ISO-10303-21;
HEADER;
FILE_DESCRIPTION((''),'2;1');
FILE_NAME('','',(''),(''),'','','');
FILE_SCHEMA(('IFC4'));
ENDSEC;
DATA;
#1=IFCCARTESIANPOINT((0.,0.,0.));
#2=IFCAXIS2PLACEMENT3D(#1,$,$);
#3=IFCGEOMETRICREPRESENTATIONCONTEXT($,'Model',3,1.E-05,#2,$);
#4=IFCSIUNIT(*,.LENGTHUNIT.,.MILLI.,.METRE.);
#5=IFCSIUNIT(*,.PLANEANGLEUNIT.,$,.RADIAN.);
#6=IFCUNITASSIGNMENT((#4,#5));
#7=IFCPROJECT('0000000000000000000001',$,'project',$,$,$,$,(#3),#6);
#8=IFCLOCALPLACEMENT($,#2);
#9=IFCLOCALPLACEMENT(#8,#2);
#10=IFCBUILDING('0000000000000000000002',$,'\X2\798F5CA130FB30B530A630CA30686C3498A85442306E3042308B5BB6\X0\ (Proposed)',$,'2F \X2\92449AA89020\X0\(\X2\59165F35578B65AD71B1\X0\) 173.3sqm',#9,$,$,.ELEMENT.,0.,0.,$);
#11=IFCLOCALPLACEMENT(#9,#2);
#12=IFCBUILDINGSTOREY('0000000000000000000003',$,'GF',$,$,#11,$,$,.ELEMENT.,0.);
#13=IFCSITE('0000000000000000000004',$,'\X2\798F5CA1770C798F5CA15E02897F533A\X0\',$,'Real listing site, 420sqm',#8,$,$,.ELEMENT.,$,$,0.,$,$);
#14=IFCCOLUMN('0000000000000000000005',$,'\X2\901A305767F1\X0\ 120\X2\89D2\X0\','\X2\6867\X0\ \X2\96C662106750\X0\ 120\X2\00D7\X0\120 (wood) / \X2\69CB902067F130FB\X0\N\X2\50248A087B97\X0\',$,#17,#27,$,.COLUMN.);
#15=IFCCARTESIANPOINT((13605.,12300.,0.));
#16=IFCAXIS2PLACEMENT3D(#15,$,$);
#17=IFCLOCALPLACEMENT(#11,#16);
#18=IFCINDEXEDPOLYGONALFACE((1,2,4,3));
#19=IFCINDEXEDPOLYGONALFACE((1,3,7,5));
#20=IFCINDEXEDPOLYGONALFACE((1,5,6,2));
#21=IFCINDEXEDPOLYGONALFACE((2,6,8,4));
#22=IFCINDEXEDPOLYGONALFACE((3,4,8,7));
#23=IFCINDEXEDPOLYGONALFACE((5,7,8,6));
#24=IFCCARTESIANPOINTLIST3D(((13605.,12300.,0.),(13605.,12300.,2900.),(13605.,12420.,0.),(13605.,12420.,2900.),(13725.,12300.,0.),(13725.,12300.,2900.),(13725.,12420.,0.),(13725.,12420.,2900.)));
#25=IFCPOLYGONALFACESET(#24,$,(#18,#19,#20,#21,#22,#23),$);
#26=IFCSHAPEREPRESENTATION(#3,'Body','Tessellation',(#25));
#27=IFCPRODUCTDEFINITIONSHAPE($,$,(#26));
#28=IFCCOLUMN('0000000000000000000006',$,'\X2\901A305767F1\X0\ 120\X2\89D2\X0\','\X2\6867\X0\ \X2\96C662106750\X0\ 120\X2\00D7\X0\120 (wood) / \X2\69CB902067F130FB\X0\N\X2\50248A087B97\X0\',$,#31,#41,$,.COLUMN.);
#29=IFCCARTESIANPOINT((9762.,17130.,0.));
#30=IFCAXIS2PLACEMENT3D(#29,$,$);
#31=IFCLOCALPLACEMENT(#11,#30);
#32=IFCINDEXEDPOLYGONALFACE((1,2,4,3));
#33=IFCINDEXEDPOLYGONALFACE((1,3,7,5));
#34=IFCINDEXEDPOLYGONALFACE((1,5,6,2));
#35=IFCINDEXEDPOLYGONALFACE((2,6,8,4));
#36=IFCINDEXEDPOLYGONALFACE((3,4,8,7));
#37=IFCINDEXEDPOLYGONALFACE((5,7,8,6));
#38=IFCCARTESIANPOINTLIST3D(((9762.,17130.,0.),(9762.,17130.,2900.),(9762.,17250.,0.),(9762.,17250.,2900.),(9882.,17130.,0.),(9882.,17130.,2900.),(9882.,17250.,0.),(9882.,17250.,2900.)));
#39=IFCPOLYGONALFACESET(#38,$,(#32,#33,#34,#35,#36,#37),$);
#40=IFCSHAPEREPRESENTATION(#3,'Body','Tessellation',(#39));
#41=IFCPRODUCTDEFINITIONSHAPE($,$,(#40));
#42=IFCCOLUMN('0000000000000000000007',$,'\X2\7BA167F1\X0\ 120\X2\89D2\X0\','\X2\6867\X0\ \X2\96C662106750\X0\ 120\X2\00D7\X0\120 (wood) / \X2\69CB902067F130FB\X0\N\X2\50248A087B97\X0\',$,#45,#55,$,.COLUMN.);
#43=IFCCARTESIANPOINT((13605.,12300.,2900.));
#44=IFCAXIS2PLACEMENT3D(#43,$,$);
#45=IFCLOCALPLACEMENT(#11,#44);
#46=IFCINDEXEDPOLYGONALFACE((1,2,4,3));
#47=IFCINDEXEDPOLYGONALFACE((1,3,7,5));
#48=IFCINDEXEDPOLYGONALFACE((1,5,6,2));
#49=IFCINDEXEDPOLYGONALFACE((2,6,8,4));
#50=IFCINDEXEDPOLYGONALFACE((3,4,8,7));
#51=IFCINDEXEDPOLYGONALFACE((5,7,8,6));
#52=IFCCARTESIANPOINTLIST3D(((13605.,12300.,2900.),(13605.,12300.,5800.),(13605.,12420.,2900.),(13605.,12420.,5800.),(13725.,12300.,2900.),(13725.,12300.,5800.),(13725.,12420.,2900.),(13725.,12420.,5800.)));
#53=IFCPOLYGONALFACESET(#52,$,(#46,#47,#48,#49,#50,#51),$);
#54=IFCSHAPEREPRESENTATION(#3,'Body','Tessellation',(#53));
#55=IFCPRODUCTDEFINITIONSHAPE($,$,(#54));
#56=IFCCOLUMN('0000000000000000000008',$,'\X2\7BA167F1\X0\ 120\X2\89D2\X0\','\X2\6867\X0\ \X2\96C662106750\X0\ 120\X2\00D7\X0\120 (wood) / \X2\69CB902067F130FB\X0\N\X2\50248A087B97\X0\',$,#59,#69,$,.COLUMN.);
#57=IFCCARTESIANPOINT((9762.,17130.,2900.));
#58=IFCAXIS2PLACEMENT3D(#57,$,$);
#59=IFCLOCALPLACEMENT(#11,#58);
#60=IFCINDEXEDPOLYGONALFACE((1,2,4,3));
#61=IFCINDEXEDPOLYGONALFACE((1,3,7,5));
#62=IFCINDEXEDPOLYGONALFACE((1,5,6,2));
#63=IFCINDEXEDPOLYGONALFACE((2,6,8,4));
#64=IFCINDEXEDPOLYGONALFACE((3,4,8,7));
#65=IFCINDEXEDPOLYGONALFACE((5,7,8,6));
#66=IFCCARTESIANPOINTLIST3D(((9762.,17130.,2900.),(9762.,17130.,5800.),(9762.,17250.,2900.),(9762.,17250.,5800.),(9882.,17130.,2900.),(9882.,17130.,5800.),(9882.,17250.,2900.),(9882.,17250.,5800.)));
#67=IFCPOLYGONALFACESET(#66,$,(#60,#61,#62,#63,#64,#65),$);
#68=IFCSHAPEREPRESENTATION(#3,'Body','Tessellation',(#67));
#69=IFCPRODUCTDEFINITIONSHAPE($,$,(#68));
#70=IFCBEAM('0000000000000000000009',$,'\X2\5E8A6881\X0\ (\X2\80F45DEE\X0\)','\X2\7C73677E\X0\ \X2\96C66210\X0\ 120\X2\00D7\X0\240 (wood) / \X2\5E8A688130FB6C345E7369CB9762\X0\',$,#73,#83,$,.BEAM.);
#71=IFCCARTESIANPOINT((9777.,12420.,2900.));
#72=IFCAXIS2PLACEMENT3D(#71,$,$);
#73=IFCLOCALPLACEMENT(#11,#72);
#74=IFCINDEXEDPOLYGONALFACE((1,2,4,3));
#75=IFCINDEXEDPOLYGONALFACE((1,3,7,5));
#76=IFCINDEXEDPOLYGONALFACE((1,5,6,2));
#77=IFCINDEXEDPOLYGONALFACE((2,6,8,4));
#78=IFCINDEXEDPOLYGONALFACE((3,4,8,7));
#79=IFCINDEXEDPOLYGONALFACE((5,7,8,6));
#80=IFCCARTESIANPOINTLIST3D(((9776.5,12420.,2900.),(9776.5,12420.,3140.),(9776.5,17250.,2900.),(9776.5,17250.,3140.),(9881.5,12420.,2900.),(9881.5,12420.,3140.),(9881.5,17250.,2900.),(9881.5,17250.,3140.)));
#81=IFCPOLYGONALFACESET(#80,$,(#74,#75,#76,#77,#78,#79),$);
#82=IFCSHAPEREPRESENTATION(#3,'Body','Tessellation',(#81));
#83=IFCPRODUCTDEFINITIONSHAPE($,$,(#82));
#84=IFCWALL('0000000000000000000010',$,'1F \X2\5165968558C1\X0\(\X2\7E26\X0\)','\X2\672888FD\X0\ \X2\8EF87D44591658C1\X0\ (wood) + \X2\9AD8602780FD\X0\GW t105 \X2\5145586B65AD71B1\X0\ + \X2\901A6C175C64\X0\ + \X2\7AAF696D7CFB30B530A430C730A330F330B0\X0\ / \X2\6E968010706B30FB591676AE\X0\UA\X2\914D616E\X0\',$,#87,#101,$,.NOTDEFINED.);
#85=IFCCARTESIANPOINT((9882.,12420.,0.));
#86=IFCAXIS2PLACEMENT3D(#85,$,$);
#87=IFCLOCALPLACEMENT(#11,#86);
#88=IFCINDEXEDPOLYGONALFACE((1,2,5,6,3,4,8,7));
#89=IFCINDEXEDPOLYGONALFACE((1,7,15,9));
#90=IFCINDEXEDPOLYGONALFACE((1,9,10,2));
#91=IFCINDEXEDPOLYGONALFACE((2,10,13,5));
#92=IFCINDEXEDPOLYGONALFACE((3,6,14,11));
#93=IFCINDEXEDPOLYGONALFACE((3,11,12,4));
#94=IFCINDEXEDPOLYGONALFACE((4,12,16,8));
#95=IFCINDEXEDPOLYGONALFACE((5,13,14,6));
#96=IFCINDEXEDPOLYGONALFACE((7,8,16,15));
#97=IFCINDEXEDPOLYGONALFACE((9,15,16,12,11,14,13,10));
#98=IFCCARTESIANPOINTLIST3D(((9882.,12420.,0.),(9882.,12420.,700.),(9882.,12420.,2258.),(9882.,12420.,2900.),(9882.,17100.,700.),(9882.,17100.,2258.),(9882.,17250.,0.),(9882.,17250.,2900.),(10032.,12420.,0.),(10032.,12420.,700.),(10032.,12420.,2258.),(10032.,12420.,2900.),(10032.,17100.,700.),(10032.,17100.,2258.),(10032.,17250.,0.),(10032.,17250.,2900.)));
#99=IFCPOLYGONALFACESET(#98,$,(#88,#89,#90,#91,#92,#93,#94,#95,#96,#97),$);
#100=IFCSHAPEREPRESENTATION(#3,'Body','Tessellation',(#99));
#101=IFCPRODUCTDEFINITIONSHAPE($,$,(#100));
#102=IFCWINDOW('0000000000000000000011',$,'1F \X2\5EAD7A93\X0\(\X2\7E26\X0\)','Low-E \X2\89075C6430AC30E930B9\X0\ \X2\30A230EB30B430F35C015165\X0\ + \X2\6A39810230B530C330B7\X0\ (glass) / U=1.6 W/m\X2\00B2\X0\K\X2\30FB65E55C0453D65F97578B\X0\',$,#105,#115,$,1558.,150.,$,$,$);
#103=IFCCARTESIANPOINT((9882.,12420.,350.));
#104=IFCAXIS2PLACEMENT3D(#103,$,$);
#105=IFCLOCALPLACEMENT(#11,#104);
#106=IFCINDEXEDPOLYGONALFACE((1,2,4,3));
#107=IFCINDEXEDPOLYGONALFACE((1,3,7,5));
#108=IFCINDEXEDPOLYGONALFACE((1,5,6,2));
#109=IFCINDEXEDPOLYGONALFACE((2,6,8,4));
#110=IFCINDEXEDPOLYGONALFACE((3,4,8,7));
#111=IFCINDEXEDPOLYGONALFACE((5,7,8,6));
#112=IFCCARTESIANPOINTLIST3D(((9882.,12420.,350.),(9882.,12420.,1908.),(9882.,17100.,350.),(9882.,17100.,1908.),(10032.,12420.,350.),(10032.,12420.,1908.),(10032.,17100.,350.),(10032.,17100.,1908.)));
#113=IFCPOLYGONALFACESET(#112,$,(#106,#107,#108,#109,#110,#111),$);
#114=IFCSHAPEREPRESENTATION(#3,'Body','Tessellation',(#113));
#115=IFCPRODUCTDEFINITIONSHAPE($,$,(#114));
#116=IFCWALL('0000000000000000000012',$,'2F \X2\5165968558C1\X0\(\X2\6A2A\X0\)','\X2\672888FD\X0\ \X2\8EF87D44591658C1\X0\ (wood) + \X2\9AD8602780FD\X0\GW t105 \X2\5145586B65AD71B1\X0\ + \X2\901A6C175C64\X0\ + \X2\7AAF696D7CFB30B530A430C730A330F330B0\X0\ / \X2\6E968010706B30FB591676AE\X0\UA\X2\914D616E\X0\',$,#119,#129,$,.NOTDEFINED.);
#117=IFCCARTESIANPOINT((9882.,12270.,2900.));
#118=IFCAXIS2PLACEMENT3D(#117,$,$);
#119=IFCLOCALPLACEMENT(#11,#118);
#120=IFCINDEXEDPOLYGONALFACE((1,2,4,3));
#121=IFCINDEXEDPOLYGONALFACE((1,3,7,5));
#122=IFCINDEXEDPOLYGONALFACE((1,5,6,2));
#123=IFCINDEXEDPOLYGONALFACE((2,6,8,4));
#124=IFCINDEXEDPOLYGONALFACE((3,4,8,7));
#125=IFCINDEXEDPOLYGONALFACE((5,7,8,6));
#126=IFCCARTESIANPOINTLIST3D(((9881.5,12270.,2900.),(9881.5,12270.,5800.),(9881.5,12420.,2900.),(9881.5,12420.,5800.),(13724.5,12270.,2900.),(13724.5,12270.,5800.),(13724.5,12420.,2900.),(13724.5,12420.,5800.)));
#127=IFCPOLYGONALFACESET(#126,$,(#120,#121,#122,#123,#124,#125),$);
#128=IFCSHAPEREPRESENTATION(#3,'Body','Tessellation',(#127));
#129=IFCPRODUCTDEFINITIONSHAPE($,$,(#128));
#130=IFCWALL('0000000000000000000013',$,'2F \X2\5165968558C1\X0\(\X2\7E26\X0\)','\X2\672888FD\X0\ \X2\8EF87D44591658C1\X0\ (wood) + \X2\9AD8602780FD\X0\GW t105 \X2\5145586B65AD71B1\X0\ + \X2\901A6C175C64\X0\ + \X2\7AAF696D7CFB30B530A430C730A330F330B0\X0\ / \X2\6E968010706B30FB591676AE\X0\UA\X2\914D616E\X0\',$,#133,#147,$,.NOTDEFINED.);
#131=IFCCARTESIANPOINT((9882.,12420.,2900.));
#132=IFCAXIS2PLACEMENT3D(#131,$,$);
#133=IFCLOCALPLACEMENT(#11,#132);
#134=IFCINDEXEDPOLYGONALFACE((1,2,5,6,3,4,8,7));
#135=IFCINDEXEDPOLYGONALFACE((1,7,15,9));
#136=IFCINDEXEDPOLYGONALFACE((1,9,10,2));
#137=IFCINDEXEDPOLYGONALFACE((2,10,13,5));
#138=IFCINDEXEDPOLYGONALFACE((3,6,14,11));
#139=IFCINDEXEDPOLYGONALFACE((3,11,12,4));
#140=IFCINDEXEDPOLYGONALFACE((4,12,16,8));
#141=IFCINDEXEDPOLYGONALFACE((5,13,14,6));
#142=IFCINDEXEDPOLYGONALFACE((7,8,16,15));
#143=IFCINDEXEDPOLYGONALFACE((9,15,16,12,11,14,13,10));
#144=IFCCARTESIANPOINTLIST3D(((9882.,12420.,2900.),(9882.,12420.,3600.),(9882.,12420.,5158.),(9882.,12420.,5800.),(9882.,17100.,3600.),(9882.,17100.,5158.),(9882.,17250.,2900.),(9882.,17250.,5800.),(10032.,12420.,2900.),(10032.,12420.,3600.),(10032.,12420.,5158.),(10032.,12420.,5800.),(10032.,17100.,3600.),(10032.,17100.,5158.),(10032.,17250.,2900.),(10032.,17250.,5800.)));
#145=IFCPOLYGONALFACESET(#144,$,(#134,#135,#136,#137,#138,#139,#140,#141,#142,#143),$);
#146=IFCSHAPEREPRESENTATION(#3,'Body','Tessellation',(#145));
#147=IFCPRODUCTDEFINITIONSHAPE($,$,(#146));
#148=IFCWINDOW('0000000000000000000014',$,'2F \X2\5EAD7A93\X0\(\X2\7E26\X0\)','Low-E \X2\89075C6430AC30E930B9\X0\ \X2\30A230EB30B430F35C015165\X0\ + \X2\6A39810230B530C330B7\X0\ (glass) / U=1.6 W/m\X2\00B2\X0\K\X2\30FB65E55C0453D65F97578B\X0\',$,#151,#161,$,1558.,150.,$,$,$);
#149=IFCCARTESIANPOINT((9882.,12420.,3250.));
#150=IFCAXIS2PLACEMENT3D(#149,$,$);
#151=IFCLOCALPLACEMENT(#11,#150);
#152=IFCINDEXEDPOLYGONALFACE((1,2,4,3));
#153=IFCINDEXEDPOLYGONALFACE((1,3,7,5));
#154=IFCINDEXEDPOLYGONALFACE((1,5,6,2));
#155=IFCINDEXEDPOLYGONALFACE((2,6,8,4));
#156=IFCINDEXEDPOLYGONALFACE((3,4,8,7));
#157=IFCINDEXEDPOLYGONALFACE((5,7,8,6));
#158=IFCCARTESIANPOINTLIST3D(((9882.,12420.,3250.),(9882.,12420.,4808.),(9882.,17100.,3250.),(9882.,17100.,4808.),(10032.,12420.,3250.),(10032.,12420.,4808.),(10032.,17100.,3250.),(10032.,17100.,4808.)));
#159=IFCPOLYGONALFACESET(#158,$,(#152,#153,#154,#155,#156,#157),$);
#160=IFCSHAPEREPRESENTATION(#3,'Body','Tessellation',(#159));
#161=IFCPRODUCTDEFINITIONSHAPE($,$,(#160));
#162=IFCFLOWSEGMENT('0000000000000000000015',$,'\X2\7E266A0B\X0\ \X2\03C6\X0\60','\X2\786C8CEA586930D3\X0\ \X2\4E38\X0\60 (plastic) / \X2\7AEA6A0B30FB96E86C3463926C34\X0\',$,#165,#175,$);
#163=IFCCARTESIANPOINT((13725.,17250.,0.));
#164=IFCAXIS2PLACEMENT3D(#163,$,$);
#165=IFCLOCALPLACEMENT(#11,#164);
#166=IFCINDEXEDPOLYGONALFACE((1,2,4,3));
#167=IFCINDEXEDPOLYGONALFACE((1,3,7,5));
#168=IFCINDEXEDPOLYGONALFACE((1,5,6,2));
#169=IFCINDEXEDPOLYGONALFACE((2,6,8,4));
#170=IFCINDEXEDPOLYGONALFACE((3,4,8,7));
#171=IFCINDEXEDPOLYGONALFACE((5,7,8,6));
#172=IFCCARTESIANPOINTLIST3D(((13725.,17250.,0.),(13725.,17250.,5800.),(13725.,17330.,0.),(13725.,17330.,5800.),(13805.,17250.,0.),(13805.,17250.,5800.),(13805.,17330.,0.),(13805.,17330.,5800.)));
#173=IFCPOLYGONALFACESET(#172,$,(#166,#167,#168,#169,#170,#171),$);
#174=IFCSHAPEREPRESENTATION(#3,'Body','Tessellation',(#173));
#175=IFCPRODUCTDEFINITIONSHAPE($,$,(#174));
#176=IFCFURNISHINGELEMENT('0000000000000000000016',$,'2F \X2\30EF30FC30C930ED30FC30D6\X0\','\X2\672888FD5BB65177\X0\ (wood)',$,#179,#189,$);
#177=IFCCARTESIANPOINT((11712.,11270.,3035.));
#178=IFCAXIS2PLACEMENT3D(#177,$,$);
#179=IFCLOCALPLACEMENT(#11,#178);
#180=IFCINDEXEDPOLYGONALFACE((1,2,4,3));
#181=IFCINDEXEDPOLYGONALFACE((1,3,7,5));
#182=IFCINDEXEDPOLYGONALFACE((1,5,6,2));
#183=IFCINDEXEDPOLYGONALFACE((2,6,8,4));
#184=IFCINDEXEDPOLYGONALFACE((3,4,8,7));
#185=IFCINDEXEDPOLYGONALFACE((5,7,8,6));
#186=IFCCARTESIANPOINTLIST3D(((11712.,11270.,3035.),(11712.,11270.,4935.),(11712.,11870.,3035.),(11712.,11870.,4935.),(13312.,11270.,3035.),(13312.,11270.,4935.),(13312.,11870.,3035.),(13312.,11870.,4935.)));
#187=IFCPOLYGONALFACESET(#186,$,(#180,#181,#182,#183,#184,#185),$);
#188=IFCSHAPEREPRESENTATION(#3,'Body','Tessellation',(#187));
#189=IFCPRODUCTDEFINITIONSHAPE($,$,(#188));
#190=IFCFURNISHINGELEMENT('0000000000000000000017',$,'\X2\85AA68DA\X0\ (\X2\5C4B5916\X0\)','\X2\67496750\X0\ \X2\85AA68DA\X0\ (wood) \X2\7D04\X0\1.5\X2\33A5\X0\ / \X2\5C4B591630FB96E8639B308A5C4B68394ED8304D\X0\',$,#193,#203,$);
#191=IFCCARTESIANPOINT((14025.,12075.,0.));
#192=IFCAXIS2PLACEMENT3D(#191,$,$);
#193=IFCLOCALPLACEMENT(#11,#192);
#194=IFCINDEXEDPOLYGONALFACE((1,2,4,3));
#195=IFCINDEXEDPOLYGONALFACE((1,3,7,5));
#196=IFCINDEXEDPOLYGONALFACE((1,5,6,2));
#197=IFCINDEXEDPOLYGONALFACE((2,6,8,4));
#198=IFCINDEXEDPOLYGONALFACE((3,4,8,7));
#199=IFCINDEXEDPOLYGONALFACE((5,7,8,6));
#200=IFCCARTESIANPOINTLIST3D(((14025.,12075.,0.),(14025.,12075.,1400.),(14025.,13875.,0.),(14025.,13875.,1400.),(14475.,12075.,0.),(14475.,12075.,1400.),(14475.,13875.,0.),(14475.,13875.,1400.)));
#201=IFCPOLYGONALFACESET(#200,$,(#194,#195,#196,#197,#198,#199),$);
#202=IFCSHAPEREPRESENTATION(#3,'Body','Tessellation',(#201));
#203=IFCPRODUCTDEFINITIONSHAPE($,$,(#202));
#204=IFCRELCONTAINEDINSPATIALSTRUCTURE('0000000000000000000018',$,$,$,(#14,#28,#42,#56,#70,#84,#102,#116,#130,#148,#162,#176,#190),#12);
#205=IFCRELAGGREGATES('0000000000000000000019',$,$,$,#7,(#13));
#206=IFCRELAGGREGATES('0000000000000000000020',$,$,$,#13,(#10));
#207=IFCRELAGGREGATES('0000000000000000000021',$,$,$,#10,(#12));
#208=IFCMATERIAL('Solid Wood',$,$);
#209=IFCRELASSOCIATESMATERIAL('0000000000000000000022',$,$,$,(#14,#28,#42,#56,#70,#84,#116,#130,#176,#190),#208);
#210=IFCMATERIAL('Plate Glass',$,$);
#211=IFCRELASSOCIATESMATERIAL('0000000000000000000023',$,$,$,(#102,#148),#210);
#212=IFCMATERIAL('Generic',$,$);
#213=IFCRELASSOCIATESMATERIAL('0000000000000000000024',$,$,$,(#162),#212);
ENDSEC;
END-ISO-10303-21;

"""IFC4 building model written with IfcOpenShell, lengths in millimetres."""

from ifc_helpers import new_model, si_unit, frame, frame_2d, origin, place, context, project, spatial, rectangle, extrude, material, element, fill, save


model = new_model("IFC4")

# Units and contexts
model_context = context("Model", 3, precision=1e-05, world=origin())
ifc_project = project(units=[si_unit("LENGTHUNIT", "METRE", prefix="MILLI"), si_unit("PLANEANGLEUNIT", "RADIAN")], contexts=[model_context])

# Site, building, storey
site_placement = place(None, origin())
site = spatial("IfcSite", under=ifc_project, at=site_placement, Name="福岡県福岡市西区", ObjectType="Real listing site, 420sqm", CompositionType="ELEMENT", RefElevation=0.0)
building_placement = place(site_placement, origin())
building = spatial("IfcBuilding", under=site, at=building_placement, Name="福岡・サウナと水風呂のある家 (Proposed)", ObjectType="2F 鉄骨造(外張型断熱) 173.3sqm", CompositionType="ELEMENT", ElevationOfRefHeight=0.0, ElevationOfTerrain=0.0)
storey_placement = place(building_placement, origin())
storey = spatial("IfcBuildingStorey", under=building, at=storey_placement, Name="GF", CompositionType="ELEMENT", Elevation=0.0)

# Columns
ifc_material_1 = material(Name="Solid Wood")
column_1_placement = place(storey_placement, frame((13605.0, 12300.0, 0.0)))
element("IfcColumn", 1, at=column_1_placement, inside=storey, material=ifc_material_1, Name="通し柱 120角", Description="桧 集成材 120×120 (wood) / 構造柱・N値計算", PredefinedType="COLUMN", context=model_context, shape_type="SweptSolid", body=[
    extrude(rectangle(XDim=120.0, YDim=120.0, at=frame_2d((60.0, 60.0))), frame((13605.0, 12300.0, 0.0)), (0.0, 0.0, 1.0), 2900.0),
])
column_2_placement = place(storey_placement, frame((9762.0, 17130.0, 0.0)))
element("IfcColumn", 2, at=column_2_placement, inside=storey, material=ifc_material_1, Name="通し柱 120角", Description="桧 集成材 120×120 (wood) / 構造柱・N値計算", PredefinedType="COLUMN", context=model_context, shape_type="SweptSolid", body=[
    extrude(rectangle(XDim=120.0, YDim=120.0, at=frame_2d((60.0, 60.0))), frame((9762.0, 17130.0, 0.0)), (0.0, 0.0, 1.0), 2900.0),
])
column_3_placement = place(storey_placement, frame((13605.0, 12300.0, 2900.0)))
element("IfcColumn", 3, at=column_3_placement, inside=storey, material=ifc_material_1, Name="管柱 120角", Description="桧 集成材 120×120 (wood) / 構造柱・N値計算", PredefinedType="COLUMN", context=model_context, shape_type="SweptSolid", body=[
    extrude(rectangle(XDim=120.0, YDim=120.0, at=frame_2d((60.0, 60.0))), frame((13605.0, 12300.0, 2900.0)), (0.0, 0.0, 1.0), 2900.0),
])
column_4_placement = place(storey_placement, frame((9762.0, 17130.0, 2900.0)))
element("IfcColumn", 4, at=column_4_placement, inside=storey, material=ifc_material_1, Name="管柱 120角", Description="桧 集成材 120×120 (wood) / 構造柱・N値計算", PredefinedType="COLUMN", context=model_context, shape_type="SweptSolid", body=[
    extrude(rectangle(XDim=120.0, YDim=120.0, at=frame_2d((60.0, 60.0))), frame((9762.0, 17130.0, 2900.0)), (0.0, 0.0, 1.0), 2900.0),
])

# Beam
beam_1_placement = place(storey_placement, frame((9777.0, 12420.0, 2900.0)))
element("IfcBeam", 5, at=beam_1_placement, inside=storey, material=ifc_material_1, Name="床梁 (胴差)", Description="米松 集成 120×240 (wood) / 床梁・水平構面", PredefinedType="BEAM", context=model_context, shape_type="SweptSolid", body=[
    extrude(rectangle(XDim=105.0, YDim=4830.0, at=frame_2d((52.0, 2415.0))), frame((9777.0, 12420.0, 2900.0)), (0.0, 0.0, 1.0), 240.0),
])

# Wall, opening, window
wall_1_placement = place(storey_placement, frame((9882.0, 12420.0, 0.0)))
wall_1 = element("IfcWall", 6, at=wall_1_placement, inside=storey, material=ifc_material_1, Name="1F 入隅壁(縦)", Description="木製 軸組外壁 (wood) + 高性能GW t105 充填断熱 + 通気層 + 窯業系サイディング / 準耐火・外皮UA配慮", PredefinedType="NOTDEFINED", context=model_context, shape_type="SweptSolid", body=[
    extrude(rectangle(XDim=150.0, YDim=4830.0, at=frame_2d((75.0, 2415.0))), frame((9882.0, 12420.0, 0.0)), (0.0, 0.0, 1.0), 2900.0),
])
opening_1_placement = place(storey_placement, frame((9882.0, 12420.0, 350.0)))
opening_1 = element("IfcOpeningElement", 7, at=opening_1_placement, cuts=wall_1, PredefinedType="NOTDEFINED", context=model_context, shape_type="SweptSolid", body=[
    extrude(rectangle(XDim=150.0, YDim=4680.0, at=frame_2d((75.0, 2340.0))), frame((9882.0, 12420.0, 350.0)), (0.0, 0.0, 1.0), 1558.0),
])
ifc_material_2 = material(Name="Plate Glass")
window_1_placement = place(storey_placement, frame((9882.0, 12420.0, 350.0)))
window_1 = element("IfcWindow", 8, at=window_1_placement, inside=storey, material=ifc_material_2, Name="1F 庭窓(縦)", Description="Low-E 複層ガラス アルゴン封入 + 樹脂サッシ (glass) / U=1.6 W/m²K・日射取得型", OverallHeight=1558.0, OverallWidth=150.0, context=model_context, shape_type="SweptSolid", body=[
    extrude(rectangle(XDim=150.0, YDim=4680.0, at=frame_2d((75.0, 2340.0))), frame((9882.0, 12420.0, 350.0)), (0.0, 0.0, 1.0), 1558.0),
])
fill(opening_1, window_1)

# Wall
wall_2_placement = place(storey_placement, frame((9882.0, 12270.0, 2900.0)))
element("IfcWall", 9, at=wall_2_placement, inside=storey, material=ifc_material_1, Name="2F 入隅壁(横)", Description="木製 軸組外壁 (wood) + 高性能GW t105 充填断熱 + 通気層 + 窯業系サイディング / 準耐火・外皮UA配慮", PredefinedType="NOTDEFINED", context=model_context, shape_type="SweptSolid", body=[
    extrude(rectangle(XDim=3843.0, YDim=150.0, at=frame_2d((1921.0, 75.0))), frame((9882.0, 12270.0, 2900.0)), (0.0, 0.0, 1.0), 2900.0),
])

# Wall, opening, window
wall_3_placement = place(storey_placement, frame((9882.0, 12420.0, 2900.0)))
wall_3 = element("IfcWall", 10, at=wall_3_placement, inside=storey, material=ifc_material_1, Name="2F 入隅壁(縦)", Description="木製 軸組外壁 (wood) + 高性能GW t105 充填断熱 + 通気層 + 窯業系サイディング / 準耐火・外皮UA配慮", PredefinedType="NOTDEFINED", context=model_context, shape_type="SweptSolid", body=[
    extrude(rectangle(XDim=150.0, YDim=4830.0, at=frame_2d((75.0, 2415.0))), frame((9882.0, 12420.0, 2900.0)), (0.0, 0.0, 1.0), 2900.0),
])
opening_2_placement = place(storey_placement, frame((9882.0, 12420.0, 3250.0)))
opening_2 = element("IfcOpeningElement", 11, at=opening_2_placement, cuts=wall_3, PredefinedType="NOTDEFINED", context=model_context, shape_type="SweptSolid", body=[
    extrude(rectangle(XDim=150.0, YDim=4680.0, at=frame_2d((75.0, 2340.0))), frame((9882.0, 12420.0, 3250.0)), (0.0, 0.0, 1.0), 1558.0),
])
window_2_placement = place(storey_placement, frame((9882.0, 12420.0, 3250.0)))
window_2 = element("IfcWindow", 12, at=window_2_placement, inside=storey, material=ifc_material_2, Name="2F 庭窓(縦)", Description="Low-E 複層ガラス アルゴン封入 + 樹脂サッシ (glass) / U=1.6 W/m²K・日射取得型", OverallHeight=1558.0, OverallWidth=150.0, context=model_context, shape_type="SweptSolid", body=[
    extrude(rectangle(XDim=150.0, YDim=4680.0, at=frame_2d((75.0, 2340.0))), frame((9882.0, 12420.0, 3250.0)), (0.0, 0.0, 1.0), 1558.0),
])
fill(opening_2, window_2)

# Flow segment
ifc_material_3 = material(Name="Generic")
flow_segment_placement = place(storey_placement, frame((13725.0, 17250.0, 0.0)))
element("IfcFlowSegment", 13, at=flow_segment_placement, inside=storey, material=ifc_material_3, Name="縦樋 φ60", Description="硬質塩ビ 丸60 (plastic) / 竪樋・雨水排水", context=model_context, shape_type="SweptSolid", body=[
    extrude(rectangle(XDim=80.0, YDim=80.0, at=frame_2d((40.0, 40.0))), frame((13725.0, 17250.0, 0.0)), (0.0, 0.0, 1.0), 5800.0),
])

# Furnishing elements
furnishing_1_placement = place(storey_placement, frame((11712.0, 11270.0, 3035.0)))
element("IfcFurnishingElement", 14, at=furnishing_1_placement, inside=storey, material=ifc_material_1, Name="2F ワードローブ", Description="木製家具 (wood)", context=model_context, shape_type="SweptSolid", body=[
    extrude(rectangle(XDim=1600.0, YDim=600.0, at=frame_2d((800.0, 300.0))), frame((11712.0, 11270.0, 3035.0)), (0.0, 0.0, 1.0), 1900.0),
])
furnishing_2_placement = place(storey_placement, frame((14025.0, 12075.0, 0.0)))
element("IfcFurnishingElement", 15, at=furnishing_2_placement, inside=storey, material=ifc_material_1, Name="薪棚 (屋外)", Description="杉材 薪棚 (wood) 約1.5㎥ / 屋外・雨掛り屋根付き", context=model_context, shape_type="SweptSolid", body=[
    extrude(rectangle(XDim=450.0, YDim=1800.0, at=frame_2d((225.0, 900.0))), frame((14025.0, 12075.0, 0.0)), (0.0, 0.0, 1.0), 1400.0),
])

save(model, "model.ifc")
